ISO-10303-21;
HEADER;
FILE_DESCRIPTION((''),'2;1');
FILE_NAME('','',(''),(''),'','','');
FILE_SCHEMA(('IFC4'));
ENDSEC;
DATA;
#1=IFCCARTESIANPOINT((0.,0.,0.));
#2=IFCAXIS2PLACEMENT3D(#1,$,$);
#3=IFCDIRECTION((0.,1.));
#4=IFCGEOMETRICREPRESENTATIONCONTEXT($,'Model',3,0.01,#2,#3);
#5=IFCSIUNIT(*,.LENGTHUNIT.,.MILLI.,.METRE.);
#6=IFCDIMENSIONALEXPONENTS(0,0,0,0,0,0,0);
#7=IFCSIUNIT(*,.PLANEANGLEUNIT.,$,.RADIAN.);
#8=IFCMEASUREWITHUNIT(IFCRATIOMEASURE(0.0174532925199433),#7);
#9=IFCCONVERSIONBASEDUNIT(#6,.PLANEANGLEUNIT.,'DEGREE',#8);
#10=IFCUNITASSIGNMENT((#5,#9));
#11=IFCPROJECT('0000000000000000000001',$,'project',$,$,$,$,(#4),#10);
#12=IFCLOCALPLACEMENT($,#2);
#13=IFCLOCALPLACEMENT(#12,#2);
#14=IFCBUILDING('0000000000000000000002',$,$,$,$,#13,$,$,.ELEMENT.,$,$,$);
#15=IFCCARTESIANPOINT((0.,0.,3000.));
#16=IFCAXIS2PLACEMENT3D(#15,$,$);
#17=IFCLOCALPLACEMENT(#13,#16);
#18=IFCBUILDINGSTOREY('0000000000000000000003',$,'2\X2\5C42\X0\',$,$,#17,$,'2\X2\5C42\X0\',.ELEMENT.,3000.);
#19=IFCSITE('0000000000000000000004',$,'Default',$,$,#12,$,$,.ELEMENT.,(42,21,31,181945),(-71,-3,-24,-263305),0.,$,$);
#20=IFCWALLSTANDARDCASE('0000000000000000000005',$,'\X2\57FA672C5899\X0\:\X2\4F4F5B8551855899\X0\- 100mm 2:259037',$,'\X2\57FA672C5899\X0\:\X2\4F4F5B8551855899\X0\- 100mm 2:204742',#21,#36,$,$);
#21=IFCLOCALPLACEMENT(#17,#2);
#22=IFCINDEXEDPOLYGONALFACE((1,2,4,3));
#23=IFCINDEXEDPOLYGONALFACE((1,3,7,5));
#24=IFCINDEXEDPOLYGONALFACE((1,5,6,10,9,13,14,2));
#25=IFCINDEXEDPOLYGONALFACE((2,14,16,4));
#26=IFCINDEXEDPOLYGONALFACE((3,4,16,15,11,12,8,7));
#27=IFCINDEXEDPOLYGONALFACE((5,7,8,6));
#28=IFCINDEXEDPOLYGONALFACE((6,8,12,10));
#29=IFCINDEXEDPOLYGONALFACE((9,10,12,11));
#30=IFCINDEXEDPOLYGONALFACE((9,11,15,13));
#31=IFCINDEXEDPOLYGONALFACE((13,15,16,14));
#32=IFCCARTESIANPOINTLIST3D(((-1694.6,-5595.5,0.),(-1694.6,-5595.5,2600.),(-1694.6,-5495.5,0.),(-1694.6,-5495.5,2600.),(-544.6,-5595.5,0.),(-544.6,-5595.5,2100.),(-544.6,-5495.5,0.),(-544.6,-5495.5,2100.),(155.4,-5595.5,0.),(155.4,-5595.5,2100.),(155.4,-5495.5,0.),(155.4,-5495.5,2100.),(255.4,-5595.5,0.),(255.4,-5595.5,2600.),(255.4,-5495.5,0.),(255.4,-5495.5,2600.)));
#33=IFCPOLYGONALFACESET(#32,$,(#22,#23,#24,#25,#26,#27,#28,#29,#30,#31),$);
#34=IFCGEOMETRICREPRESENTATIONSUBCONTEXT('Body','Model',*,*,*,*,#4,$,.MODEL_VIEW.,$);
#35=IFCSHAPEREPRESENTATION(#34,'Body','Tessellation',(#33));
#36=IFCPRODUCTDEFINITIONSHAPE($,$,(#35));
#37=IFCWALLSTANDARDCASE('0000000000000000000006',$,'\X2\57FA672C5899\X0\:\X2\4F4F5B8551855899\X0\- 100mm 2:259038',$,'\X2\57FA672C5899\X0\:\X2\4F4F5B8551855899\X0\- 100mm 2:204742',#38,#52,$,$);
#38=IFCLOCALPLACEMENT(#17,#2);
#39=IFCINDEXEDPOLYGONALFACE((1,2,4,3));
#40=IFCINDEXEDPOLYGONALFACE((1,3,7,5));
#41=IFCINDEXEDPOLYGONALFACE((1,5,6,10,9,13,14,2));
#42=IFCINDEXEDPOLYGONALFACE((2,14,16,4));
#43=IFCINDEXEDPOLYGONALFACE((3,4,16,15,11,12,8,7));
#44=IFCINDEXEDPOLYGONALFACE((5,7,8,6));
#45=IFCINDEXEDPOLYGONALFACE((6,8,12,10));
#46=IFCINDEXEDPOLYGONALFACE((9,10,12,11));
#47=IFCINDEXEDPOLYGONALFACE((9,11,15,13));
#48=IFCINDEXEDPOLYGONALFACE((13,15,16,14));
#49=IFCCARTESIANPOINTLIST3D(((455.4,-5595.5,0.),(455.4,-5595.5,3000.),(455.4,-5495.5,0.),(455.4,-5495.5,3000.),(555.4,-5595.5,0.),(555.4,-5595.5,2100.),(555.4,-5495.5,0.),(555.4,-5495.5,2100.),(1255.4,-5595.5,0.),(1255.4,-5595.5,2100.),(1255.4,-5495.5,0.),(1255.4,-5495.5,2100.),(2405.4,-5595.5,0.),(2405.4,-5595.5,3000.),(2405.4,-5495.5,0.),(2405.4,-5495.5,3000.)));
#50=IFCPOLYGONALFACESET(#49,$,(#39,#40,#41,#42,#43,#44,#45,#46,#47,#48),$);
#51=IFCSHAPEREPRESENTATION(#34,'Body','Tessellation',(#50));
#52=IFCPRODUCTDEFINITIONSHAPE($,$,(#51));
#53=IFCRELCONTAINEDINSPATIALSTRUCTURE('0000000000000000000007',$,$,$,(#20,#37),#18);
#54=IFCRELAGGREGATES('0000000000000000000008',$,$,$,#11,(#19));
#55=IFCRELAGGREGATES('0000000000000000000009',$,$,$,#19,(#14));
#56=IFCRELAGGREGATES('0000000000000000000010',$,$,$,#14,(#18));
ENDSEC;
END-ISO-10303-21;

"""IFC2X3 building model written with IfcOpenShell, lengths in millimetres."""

from ifc_helpers import new_model, entity, si_unit, converted_unit, direction, frame, frame_2d, origin, place, context, subcontext, project, spatial, polyline, rectangle, extrude, clip, bounded_halfspace, element, save


model = new_model("IFC2X3")

# Units and contexts
model_context = context("Model", 3, precision=0.01, world=origin(), true_north=direction((0.0, 1.0)))
body_context = subcontext(model_context, "Body", "Model", "MODEL_VIEW")
ifc_project = project(units=[si_unit("LENGTHUNIT", "METRE", prefix="MILLI"), converted_unit("PLANEANGLEUNIT", "DEGREE", entity("IfcRatioMeasure", 0.0174532925199433), si_unit("PLANEANGLEUNIT", "RADIAN"), dimensions=[0, 0, 0, 0, 0, 0, 0])], contexts=[model_context])

# Site, building, storey
site_placement = place(None, origin())
site = spatial("IfcSite", under=ifc_project, at=site_placement, Name="Default", CompositionType="ELEMENT", RefLatitude=(42, 21, 31, 181945), RefLongitude=(-71, -3, -24, -263305), RefElevation=0.0)
building_placement = place(site_placement, origin())
building = spatial("IfcBuilding", under=site, at=building_placement, CompositionType="ELEMENT")
storey_placement = place(building_placement, frame((0.0, 0.0, 3000.0)))
storey = spatial("IfcBuildingStorey", under=building, at=storey_placement, Name="2层", LongName="2层", CompositionType="ELEMENT", Elevation=3000.0)

# Walls, openings
wall_1_placement = place(storey_placement, frame((-1694.6, -5545.5, 0.0)))
wall_1 = element("IfcWallStandardCase", 1, at=wall_1_placement, inside=storey, Name="基本墙:住宅内墙- 100mm 2:259037", ObjectType="基本墙:住宅内墙- 100mm 2:204742", context=body_context, shape_type="Clipping", body=[
    clip(extrude(rectangle(XDim=1950.0, YDim=100.0, at=frame_2d((975.0, 0.0), x_axis=(-1.0, 0.0))), origin(), (0.0, 0.0, 1.0), 2600.0), bounded_halfspace(frame((0.0, -50.0, 2600.0), z_axis=(0.0, 0.0, -1.0), x_axis=(-1.0, 0.0, 0.0)), True, frame((0.0, -50.0, 2600.0), z_axis=(0.0, 0.0, -1.0), x_axis=(-1.0, 0.0, 0.0)), polyline([(0.0, 0.0), (0.0, 100.0), (-1950.0, 100.0), (-1950.0, 0.0), (0.0, 0.0)]))),
])
opening_1_placement = place(wall_1_placement, frame((1150.0, -50.0, 0.0)))
element("IfcOpeningElement", 2, at=opening_1_placement, cuts=wall_1, ObjectType="Opening", context=body_context, shape_type="SweptSolid", body=[
    extrude(rectangle(XDim=2100.0, YDim=700.0, at=frame_2d((1050.0, 350.0), x_axis=(1.0, 0.0))), frame((0.0, 0.0, 0.0), z_axis=(0.0, 1.0, 0.0), x_axis=(0.0, 0.0, 1.0)), (0.0, 0.0, 1.0), 100.0),
])
wall_2_placement = place(storey_placement, frame((2405.4, -5545.5, 0.0), z_axis=(0.0, 0.0, 1.0), x_axis=(-1.0, 0.0, 0.0)))
wall_2 = element("IfcWallStandardCase", 3, at=wall_2_placement, inside=storey, Name="基本墙:住宅内墙- 100mm 2:259038", ObjectType="基本墙:住宅内墙- 100mm 2:204742", context=body_context, shape_type="SweptSolid", body=[
    extrude(rectangle(XDim=1950.0, YDim=100.0, at=frame_2d((975.0, 0.0), x_axis=(-1.0, 0.0))), origin(), (0.0, 0.0, 1.0), 3000.0),
])
opening_2_placement = place(wall_2_placement, frame((1850.0, 50.0, 0.0)))
element("IfcOpeningElement", 4, at=opening_2_placement, cuts=wall_2, ObjectType="Opening", context=body_context, shape_type="SweptSolid", body=[
    extrude(rectangle(XDim=2100.0, YDim=700.0, at=frame_2d((1050.0, 350.0), x_axis=(1.0, 0.0))), frame((0.0, 0.0, 0.0), z_axis=(0.0, -1.0, 0.0), x_axis=(0.0, 0.0, 1.0)), (0.0, 0.0, 1.0), 100.0),
])

save(model, "model.ifc")
